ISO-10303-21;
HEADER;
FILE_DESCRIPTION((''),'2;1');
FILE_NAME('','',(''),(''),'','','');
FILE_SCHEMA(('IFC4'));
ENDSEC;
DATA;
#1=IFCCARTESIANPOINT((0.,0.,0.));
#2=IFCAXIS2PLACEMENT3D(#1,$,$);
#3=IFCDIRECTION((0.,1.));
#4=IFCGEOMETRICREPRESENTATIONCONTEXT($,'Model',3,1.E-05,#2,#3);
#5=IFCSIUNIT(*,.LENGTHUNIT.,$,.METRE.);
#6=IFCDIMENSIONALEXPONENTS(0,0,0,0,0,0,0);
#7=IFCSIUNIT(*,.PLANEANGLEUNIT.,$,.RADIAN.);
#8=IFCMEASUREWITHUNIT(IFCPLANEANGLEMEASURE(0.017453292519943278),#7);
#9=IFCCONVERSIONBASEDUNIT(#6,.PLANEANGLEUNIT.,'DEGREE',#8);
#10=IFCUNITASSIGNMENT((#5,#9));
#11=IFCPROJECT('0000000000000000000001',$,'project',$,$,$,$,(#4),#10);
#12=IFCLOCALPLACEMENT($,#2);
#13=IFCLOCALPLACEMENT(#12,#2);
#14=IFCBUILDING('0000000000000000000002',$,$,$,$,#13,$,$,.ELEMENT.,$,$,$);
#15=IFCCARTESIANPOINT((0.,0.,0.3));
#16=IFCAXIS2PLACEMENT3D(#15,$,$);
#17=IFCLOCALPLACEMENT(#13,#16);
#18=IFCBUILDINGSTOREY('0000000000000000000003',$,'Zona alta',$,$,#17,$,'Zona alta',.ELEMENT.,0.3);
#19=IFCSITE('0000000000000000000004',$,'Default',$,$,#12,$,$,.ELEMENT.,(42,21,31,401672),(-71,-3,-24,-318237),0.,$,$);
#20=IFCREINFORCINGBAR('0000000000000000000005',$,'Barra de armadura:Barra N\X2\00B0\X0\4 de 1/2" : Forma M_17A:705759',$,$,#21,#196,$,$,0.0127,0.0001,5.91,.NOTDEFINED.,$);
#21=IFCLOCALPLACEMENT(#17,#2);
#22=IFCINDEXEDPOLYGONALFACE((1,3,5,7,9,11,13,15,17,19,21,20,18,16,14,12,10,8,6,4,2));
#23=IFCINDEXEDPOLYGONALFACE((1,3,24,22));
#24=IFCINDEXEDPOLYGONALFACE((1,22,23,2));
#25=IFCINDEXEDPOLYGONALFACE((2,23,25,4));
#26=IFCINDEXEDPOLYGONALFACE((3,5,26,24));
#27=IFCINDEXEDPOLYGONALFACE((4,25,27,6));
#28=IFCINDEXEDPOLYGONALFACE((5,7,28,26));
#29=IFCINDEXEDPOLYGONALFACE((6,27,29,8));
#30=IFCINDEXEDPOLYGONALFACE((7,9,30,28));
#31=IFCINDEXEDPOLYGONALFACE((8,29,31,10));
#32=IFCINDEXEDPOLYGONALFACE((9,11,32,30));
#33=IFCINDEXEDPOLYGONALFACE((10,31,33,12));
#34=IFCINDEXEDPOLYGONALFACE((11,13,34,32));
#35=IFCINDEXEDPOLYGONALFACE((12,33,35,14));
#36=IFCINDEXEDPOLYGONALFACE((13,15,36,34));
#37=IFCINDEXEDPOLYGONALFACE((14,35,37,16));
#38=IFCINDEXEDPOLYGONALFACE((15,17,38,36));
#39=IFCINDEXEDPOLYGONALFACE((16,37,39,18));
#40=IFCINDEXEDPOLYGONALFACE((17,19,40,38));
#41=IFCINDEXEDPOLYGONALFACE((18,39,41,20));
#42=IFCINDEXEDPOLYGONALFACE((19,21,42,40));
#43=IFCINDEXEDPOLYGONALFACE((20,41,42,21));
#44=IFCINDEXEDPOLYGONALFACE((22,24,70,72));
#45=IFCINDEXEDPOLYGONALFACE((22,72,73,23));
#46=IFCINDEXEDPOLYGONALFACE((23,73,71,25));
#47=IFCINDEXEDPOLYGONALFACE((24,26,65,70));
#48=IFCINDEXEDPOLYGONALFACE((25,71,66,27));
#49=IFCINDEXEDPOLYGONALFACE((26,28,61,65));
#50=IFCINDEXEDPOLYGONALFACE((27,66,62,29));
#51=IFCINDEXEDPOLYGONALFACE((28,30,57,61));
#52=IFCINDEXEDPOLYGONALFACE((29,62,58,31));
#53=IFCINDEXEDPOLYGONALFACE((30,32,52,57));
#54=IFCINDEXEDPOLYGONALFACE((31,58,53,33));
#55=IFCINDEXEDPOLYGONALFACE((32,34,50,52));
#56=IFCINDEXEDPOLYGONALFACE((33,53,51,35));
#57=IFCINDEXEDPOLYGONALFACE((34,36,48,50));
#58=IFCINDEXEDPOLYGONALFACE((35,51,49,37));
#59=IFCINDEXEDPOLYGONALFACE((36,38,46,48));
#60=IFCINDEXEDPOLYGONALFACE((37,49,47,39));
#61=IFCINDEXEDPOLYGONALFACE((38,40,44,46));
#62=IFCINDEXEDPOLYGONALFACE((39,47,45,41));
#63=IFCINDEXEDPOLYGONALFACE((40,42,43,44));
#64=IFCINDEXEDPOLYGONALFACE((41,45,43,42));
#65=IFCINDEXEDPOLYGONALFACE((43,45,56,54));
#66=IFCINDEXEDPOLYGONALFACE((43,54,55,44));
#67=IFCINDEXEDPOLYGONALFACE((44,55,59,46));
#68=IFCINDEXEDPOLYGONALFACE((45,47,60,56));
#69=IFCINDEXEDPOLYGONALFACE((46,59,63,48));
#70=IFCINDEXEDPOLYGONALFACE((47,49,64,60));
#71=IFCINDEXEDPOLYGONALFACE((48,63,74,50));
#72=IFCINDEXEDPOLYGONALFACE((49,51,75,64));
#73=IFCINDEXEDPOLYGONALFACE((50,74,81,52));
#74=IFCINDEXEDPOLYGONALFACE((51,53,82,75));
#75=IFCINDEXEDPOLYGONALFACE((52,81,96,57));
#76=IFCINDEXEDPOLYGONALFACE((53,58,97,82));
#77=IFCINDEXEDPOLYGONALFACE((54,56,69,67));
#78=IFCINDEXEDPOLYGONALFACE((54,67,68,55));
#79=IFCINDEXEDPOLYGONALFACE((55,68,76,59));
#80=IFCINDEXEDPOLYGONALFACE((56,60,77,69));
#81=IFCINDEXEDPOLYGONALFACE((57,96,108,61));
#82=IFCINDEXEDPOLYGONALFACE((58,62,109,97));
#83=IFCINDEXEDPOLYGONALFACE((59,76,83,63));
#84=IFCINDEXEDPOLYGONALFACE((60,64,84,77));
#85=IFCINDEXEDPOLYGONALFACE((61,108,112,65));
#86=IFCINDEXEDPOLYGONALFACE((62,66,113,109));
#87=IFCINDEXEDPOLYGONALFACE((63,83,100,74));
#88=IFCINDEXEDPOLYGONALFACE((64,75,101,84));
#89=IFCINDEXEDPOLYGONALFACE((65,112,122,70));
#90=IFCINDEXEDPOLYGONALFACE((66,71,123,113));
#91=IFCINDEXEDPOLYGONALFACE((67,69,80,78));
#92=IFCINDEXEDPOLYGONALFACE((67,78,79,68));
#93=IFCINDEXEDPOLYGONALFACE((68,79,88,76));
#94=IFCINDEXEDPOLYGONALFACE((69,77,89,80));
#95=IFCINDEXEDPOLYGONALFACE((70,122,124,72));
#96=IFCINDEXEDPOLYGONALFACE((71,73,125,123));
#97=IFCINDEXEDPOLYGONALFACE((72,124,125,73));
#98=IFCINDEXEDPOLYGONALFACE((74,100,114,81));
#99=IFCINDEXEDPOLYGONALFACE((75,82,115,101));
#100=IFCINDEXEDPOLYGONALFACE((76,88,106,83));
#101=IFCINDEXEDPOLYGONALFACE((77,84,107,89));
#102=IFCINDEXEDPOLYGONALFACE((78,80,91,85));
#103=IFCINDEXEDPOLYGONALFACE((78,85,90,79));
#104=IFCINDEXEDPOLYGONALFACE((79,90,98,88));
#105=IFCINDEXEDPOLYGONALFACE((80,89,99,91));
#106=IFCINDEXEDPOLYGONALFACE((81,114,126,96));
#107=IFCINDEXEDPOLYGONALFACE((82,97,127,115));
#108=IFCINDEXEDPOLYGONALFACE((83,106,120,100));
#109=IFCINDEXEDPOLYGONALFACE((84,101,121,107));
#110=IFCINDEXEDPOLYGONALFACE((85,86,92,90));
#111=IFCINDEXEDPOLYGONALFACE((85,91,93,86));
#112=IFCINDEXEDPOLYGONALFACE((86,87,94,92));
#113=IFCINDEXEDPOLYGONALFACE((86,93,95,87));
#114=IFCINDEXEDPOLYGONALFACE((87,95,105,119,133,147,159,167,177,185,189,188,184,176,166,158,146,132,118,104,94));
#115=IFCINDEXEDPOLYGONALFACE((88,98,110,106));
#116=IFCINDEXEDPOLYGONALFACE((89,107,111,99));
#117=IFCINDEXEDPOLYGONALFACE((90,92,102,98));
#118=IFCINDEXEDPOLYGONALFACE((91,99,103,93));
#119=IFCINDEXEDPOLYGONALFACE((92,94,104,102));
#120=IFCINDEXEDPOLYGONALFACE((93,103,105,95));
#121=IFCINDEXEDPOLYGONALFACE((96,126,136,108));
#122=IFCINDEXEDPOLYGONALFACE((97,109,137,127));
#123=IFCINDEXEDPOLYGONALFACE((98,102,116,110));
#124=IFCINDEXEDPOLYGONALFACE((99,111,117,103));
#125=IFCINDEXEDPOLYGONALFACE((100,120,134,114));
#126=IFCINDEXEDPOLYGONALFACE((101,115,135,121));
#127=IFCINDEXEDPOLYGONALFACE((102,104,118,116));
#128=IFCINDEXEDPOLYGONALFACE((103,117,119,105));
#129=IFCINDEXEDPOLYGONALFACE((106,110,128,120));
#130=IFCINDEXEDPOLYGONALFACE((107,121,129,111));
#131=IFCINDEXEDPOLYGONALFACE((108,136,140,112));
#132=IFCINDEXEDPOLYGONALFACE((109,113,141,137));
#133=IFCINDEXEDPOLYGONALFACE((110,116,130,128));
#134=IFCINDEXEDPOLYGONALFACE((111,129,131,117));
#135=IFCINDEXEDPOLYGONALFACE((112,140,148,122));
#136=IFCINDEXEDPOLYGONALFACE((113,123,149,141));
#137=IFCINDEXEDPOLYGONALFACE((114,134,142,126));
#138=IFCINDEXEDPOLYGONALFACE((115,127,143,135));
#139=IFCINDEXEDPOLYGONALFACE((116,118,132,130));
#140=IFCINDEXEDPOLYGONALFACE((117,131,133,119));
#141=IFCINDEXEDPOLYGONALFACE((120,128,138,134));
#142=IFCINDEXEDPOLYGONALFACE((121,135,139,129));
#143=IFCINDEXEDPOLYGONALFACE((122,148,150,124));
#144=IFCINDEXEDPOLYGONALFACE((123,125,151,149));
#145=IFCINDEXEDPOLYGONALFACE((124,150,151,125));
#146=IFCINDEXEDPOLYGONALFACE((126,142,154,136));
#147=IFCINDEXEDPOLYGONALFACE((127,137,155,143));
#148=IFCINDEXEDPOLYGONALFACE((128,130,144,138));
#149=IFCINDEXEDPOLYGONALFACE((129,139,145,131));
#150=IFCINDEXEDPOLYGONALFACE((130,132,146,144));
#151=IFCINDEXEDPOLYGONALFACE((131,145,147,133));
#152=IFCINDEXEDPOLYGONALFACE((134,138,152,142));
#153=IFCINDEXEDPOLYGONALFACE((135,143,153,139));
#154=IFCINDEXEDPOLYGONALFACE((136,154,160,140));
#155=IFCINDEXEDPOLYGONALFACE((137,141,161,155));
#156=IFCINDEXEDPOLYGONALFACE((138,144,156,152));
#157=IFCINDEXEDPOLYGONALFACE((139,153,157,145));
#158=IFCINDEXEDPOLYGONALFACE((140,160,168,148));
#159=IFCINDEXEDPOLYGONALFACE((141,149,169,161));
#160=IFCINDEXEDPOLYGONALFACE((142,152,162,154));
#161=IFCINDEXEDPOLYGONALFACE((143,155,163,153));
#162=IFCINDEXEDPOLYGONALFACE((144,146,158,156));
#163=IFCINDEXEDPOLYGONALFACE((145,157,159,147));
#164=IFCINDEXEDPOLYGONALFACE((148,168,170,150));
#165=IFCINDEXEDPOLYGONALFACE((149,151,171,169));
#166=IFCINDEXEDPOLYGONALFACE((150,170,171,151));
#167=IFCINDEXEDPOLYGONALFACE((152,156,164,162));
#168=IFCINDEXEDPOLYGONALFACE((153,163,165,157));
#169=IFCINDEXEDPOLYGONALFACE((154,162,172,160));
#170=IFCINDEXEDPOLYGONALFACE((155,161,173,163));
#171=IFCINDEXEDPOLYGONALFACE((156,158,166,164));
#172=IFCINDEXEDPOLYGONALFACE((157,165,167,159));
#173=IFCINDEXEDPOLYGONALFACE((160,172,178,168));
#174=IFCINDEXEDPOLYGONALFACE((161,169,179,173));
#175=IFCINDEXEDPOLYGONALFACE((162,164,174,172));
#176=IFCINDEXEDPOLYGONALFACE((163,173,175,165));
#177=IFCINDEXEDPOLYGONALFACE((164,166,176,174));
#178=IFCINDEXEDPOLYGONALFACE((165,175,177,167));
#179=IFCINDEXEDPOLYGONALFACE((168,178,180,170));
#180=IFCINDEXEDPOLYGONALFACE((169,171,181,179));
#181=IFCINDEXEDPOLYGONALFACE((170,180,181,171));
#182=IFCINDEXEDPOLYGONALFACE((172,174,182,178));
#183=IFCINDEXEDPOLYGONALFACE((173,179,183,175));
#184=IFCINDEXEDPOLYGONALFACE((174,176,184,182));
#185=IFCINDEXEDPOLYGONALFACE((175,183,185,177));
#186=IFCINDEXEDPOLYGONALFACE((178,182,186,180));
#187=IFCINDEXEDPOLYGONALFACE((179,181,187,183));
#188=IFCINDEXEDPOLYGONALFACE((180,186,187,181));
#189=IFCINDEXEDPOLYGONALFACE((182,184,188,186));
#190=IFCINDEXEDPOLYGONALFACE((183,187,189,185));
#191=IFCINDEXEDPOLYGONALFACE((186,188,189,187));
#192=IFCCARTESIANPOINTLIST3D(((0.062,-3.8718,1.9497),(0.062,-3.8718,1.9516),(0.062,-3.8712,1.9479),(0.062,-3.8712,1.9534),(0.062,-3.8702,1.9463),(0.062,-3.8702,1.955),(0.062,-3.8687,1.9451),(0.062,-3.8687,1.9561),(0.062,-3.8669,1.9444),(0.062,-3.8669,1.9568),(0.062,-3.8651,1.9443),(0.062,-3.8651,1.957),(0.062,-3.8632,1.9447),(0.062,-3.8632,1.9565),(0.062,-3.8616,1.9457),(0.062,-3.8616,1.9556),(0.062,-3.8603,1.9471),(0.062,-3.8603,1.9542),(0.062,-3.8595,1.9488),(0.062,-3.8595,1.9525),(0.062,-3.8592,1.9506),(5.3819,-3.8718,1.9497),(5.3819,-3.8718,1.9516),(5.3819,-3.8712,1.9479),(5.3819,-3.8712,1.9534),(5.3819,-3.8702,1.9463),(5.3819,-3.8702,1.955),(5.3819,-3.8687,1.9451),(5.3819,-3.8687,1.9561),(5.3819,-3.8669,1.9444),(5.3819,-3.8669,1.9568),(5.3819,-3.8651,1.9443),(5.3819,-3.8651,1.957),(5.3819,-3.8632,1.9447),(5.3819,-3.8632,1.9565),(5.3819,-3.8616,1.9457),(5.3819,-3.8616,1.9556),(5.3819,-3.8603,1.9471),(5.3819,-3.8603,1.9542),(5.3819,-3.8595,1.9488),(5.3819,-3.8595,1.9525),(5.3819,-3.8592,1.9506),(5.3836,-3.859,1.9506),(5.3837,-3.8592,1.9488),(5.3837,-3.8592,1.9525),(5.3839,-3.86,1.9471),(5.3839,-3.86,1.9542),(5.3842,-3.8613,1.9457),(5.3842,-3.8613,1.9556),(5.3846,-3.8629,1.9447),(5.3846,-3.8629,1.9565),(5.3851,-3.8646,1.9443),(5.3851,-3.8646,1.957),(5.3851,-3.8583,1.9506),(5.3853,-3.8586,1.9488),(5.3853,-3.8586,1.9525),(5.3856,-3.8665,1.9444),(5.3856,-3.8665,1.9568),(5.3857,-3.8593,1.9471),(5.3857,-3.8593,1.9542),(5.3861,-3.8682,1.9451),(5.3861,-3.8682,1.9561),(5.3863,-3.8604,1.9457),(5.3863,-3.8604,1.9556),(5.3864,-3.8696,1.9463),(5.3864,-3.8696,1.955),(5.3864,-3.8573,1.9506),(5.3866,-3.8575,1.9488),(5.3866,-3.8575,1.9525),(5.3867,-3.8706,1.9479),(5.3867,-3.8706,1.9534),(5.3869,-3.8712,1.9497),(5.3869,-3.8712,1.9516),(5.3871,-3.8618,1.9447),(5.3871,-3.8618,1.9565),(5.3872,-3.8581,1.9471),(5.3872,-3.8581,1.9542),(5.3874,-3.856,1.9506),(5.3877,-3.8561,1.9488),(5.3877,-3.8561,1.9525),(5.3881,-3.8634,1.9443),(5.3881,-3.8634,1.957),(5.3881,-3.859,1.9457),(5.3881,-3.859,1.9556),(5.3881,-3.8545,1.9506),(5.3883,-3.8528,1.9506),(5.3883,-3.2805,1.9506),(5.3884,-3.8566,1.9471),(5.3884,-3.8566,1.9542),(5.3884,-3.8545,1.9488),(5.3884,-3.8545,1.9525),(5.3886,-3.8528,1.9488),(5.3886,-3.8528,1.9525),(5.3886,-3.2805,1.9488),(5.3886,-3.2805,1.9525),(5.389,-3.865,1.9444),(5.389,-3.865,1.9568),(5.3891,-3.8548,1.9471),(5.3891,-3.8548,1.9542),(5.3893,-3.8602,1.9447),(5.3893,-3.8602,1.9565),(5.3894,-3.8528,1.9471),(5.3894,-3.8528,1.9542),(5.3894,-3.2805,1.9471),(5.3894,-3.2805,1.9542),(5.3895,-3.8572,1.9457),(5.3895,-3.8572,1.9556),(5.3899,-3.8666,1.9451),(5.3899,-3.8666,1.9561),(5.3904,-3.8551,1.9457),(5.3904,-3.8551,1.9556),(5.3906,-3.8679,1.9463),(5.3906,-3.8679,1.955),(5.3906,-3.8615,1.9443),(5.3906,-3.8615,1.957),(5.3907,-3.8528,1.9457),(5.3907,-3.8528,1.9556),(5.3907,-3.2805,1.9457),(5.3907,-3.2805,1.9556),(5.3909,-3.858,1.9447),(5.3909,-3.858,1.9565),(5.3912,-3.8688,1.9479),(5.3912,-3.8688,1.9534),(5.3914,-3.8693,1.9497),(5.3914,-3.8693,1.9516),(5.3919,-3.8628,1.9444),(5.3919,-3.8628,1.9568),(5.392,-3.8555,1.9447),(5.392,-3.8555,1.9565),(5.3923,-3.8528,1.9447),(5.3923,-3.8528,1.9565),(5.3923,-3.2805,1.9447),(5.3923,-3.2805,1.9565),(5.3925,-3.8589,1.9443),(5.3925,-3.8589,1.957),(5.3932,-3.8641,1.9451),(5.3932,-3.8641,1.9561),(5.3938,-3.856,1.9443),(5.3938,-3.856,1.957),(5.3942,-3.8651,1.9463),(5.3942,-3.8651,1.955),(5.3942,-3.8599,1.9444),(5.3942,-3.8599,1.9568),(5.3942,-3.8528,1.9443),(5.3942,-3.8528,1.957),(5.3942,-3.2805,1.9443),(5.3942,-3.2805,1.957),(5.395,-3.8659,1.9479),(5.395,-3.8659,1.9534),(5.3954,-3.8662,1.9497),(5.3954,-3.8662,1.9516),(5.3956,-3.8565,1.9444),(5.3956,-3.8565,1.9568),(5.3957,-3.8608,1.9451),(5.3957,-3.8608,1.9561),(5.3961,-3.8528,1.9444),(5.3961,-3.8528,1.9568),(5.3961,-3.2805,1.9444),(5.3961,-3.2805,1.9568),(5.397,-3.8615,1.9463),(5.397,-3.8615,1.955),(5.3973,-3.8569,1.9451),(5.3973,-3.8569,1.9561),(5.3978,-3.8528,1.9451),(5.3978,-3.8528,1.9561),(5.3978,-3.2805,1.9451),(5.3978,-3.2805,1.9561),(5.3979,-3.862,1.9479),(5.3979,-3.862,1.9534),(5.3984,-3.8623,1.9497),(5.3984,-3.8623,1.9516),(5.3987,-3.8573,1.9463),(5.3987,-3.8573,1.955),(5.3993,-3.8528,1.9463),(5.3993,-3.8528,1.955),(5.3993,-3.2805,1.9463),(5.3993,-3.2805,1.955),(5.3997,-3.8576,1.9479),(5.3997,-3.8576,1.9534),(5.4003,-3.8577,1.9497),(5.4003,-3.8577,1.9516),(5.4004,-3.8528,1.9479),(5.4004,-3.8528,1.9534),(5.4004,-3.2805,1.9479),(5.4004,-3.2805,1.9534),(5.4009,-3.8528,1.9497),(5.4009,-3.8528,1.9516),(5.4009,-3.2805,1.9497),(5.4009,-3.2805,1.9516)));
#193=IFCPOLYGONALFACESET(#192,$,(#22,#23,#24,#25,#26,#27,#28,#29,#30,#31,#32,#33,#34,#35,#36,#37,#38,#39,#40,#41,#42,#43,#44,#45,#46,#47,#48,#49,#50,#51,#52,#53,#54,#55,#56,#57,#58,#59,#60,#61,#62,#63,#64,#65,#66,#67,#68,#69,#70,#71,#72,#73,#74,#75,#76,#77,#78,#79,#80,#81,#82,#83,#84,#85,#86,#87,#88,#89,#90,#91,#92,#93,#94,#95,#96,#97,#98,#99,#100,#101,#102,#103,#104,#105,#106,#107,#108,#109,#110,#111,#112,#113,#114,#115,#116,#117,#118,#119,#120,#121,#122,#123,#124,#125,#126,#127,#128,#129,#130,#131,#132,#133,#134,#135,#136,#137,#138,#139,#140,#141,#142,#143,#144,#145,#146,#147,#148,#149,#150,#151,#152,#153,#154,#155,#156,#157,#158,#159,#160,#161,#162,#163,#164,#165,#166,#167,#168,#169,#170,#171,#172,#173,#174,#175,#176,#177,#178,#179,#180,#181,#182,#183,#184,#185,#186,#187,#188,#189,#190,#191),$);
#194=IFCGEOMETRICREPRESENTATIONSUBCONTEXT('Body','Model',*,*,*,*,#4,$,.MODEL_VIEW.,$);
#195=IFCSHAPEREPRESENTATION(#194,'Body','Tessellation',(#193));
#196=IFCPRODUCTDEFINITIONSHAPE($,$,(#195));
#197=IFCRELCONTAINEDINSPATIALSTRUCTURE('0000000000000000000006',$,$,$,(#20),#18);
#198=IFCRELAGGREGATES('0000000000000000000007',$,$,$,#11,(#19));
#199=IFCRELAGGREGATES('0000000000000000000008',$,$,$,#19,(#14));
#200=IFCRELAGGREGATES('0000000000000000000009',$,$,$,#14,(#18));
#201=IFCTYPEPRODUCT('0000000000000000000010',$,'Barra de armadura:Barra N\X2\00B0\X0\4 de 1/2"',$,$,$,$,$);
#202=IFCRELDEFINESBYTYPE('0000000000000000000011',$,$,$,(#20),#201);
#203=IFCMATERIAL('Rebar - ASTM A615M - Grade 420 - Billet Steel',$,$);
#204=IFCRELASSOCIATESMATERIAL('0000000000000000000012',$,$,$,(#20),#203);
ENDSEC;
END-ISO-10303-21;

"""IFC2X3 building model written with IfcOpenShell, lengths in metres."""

from ifc_helpers import new_model, entity, si_unit, converted_unit, direction, frame, origin, place, context, subcontext, project, spatial, material, type_object, element, save


model = new_model("IFC2X3")

# Units and contexts
model_context = context("Model", 3, precision=1e-05, world=origin(), true_north=direction((0.0, 1.0)))
body_context = subcontext(model_context, "Body", "Model", "MODEL_VIEW")
ifc_project = project(units=[si_unit("LENGTHUNIT", "METRE"), converted_unit("PLANEANGLEUNIT", "DEGREE", entity("IfcPlaneAngleMeasure", 0.017453292519943278), si_unit("PLANEANGLEUNIT", "RADIAN"), dimensions=[0, 0, 0, 0, 0, 0, 0])], contexts=[model_context])

# Site, building, storey
site_placement = place(None, origin())
site = spatial("IfcSite", under=ifc_project, at=site_placement, Name="Default", CompositionType="ELEMENT", RefLatitude=(42, 21, 31, 401672), RefLongitude=(-71, -3, -24, -318237), RefElevation=0.0)
building_placement = place(site_placement, origin())
building = spatial("IfcBuilding", under=site, at=building_placement, CompositionType="ELEMENT")
storey_placement = place(building_placement, frame((0.0, 0.0, 0.3)))
storey = spatial("IfcBuildingStorey", under=building, at=storey_placement, Name="Zona alta", LongName="Zona alta", CompositionType="ELEMENT", Elevation=0.3)

# Reinforcing bar
ifc_material = material(Name="Rebar - ASTM A615M - Grade 420 - Billet Steel")
type_product_1 = type_object("IfcTypeProduct", Name="Barra de armadura:Barra N°4 de 1/2\"")
reinforcing_bar_1_placement = place(storey_placement, origin())
element("IfcReinforcingBar", 1, at=reinforcing_bar_1_placement, inside=storey, type_object=type_product_1, material=ifc_material, Name="Barra de armadura:Barra N°4 de 1/2\" : Forma M_17A:705759", BarLength=5.91, BarRole="NOTDEFINED", CrossSectionArea=0.0001, NominalDiameter=0.0127, context=body_context, shape_type="AdvancedSweptSolid", body=[
    entity("IfcSweptDiskSolid", entity("IfcCompositeCurve", [entity("IfcCompositeCurveSegment", "CONTINUOUS", True, entity("IfcPolyline", [entity("IfcCartesianPoint", [0.062, -3.8655, 1.9506]), entity("IfcCartesianPoint", [5.3819, -3.8655, 1.9506])])), entity("IfcCompositeCurveSegment", "CONTINUOUS", True, entity("IfcTrimmedCurve", entity("IfcCircle", entity("IfcAxis2Placement3D", entity("IfcCartesianPoint", [5.3819, -3.8528, 1.9506])), 0.0127), [entity("IfcParameterValue", 270.0)], [entity("IfcParameterValue", 360.0)], True, "PARAMETER")), entity("IfcCompositeCurveSegment", "CONTINUOUS", True, entity("IfcPolyline", [entity("IfcCartesianPoint", [5.3946, -3.8528, 1.9506]), entity("IfcCartesianPoint", [5.3946, -3.2805, 1.9506])]))], False), 0.0063, None, 0.0, 92.0),
])

save(model, "model.ifc")
